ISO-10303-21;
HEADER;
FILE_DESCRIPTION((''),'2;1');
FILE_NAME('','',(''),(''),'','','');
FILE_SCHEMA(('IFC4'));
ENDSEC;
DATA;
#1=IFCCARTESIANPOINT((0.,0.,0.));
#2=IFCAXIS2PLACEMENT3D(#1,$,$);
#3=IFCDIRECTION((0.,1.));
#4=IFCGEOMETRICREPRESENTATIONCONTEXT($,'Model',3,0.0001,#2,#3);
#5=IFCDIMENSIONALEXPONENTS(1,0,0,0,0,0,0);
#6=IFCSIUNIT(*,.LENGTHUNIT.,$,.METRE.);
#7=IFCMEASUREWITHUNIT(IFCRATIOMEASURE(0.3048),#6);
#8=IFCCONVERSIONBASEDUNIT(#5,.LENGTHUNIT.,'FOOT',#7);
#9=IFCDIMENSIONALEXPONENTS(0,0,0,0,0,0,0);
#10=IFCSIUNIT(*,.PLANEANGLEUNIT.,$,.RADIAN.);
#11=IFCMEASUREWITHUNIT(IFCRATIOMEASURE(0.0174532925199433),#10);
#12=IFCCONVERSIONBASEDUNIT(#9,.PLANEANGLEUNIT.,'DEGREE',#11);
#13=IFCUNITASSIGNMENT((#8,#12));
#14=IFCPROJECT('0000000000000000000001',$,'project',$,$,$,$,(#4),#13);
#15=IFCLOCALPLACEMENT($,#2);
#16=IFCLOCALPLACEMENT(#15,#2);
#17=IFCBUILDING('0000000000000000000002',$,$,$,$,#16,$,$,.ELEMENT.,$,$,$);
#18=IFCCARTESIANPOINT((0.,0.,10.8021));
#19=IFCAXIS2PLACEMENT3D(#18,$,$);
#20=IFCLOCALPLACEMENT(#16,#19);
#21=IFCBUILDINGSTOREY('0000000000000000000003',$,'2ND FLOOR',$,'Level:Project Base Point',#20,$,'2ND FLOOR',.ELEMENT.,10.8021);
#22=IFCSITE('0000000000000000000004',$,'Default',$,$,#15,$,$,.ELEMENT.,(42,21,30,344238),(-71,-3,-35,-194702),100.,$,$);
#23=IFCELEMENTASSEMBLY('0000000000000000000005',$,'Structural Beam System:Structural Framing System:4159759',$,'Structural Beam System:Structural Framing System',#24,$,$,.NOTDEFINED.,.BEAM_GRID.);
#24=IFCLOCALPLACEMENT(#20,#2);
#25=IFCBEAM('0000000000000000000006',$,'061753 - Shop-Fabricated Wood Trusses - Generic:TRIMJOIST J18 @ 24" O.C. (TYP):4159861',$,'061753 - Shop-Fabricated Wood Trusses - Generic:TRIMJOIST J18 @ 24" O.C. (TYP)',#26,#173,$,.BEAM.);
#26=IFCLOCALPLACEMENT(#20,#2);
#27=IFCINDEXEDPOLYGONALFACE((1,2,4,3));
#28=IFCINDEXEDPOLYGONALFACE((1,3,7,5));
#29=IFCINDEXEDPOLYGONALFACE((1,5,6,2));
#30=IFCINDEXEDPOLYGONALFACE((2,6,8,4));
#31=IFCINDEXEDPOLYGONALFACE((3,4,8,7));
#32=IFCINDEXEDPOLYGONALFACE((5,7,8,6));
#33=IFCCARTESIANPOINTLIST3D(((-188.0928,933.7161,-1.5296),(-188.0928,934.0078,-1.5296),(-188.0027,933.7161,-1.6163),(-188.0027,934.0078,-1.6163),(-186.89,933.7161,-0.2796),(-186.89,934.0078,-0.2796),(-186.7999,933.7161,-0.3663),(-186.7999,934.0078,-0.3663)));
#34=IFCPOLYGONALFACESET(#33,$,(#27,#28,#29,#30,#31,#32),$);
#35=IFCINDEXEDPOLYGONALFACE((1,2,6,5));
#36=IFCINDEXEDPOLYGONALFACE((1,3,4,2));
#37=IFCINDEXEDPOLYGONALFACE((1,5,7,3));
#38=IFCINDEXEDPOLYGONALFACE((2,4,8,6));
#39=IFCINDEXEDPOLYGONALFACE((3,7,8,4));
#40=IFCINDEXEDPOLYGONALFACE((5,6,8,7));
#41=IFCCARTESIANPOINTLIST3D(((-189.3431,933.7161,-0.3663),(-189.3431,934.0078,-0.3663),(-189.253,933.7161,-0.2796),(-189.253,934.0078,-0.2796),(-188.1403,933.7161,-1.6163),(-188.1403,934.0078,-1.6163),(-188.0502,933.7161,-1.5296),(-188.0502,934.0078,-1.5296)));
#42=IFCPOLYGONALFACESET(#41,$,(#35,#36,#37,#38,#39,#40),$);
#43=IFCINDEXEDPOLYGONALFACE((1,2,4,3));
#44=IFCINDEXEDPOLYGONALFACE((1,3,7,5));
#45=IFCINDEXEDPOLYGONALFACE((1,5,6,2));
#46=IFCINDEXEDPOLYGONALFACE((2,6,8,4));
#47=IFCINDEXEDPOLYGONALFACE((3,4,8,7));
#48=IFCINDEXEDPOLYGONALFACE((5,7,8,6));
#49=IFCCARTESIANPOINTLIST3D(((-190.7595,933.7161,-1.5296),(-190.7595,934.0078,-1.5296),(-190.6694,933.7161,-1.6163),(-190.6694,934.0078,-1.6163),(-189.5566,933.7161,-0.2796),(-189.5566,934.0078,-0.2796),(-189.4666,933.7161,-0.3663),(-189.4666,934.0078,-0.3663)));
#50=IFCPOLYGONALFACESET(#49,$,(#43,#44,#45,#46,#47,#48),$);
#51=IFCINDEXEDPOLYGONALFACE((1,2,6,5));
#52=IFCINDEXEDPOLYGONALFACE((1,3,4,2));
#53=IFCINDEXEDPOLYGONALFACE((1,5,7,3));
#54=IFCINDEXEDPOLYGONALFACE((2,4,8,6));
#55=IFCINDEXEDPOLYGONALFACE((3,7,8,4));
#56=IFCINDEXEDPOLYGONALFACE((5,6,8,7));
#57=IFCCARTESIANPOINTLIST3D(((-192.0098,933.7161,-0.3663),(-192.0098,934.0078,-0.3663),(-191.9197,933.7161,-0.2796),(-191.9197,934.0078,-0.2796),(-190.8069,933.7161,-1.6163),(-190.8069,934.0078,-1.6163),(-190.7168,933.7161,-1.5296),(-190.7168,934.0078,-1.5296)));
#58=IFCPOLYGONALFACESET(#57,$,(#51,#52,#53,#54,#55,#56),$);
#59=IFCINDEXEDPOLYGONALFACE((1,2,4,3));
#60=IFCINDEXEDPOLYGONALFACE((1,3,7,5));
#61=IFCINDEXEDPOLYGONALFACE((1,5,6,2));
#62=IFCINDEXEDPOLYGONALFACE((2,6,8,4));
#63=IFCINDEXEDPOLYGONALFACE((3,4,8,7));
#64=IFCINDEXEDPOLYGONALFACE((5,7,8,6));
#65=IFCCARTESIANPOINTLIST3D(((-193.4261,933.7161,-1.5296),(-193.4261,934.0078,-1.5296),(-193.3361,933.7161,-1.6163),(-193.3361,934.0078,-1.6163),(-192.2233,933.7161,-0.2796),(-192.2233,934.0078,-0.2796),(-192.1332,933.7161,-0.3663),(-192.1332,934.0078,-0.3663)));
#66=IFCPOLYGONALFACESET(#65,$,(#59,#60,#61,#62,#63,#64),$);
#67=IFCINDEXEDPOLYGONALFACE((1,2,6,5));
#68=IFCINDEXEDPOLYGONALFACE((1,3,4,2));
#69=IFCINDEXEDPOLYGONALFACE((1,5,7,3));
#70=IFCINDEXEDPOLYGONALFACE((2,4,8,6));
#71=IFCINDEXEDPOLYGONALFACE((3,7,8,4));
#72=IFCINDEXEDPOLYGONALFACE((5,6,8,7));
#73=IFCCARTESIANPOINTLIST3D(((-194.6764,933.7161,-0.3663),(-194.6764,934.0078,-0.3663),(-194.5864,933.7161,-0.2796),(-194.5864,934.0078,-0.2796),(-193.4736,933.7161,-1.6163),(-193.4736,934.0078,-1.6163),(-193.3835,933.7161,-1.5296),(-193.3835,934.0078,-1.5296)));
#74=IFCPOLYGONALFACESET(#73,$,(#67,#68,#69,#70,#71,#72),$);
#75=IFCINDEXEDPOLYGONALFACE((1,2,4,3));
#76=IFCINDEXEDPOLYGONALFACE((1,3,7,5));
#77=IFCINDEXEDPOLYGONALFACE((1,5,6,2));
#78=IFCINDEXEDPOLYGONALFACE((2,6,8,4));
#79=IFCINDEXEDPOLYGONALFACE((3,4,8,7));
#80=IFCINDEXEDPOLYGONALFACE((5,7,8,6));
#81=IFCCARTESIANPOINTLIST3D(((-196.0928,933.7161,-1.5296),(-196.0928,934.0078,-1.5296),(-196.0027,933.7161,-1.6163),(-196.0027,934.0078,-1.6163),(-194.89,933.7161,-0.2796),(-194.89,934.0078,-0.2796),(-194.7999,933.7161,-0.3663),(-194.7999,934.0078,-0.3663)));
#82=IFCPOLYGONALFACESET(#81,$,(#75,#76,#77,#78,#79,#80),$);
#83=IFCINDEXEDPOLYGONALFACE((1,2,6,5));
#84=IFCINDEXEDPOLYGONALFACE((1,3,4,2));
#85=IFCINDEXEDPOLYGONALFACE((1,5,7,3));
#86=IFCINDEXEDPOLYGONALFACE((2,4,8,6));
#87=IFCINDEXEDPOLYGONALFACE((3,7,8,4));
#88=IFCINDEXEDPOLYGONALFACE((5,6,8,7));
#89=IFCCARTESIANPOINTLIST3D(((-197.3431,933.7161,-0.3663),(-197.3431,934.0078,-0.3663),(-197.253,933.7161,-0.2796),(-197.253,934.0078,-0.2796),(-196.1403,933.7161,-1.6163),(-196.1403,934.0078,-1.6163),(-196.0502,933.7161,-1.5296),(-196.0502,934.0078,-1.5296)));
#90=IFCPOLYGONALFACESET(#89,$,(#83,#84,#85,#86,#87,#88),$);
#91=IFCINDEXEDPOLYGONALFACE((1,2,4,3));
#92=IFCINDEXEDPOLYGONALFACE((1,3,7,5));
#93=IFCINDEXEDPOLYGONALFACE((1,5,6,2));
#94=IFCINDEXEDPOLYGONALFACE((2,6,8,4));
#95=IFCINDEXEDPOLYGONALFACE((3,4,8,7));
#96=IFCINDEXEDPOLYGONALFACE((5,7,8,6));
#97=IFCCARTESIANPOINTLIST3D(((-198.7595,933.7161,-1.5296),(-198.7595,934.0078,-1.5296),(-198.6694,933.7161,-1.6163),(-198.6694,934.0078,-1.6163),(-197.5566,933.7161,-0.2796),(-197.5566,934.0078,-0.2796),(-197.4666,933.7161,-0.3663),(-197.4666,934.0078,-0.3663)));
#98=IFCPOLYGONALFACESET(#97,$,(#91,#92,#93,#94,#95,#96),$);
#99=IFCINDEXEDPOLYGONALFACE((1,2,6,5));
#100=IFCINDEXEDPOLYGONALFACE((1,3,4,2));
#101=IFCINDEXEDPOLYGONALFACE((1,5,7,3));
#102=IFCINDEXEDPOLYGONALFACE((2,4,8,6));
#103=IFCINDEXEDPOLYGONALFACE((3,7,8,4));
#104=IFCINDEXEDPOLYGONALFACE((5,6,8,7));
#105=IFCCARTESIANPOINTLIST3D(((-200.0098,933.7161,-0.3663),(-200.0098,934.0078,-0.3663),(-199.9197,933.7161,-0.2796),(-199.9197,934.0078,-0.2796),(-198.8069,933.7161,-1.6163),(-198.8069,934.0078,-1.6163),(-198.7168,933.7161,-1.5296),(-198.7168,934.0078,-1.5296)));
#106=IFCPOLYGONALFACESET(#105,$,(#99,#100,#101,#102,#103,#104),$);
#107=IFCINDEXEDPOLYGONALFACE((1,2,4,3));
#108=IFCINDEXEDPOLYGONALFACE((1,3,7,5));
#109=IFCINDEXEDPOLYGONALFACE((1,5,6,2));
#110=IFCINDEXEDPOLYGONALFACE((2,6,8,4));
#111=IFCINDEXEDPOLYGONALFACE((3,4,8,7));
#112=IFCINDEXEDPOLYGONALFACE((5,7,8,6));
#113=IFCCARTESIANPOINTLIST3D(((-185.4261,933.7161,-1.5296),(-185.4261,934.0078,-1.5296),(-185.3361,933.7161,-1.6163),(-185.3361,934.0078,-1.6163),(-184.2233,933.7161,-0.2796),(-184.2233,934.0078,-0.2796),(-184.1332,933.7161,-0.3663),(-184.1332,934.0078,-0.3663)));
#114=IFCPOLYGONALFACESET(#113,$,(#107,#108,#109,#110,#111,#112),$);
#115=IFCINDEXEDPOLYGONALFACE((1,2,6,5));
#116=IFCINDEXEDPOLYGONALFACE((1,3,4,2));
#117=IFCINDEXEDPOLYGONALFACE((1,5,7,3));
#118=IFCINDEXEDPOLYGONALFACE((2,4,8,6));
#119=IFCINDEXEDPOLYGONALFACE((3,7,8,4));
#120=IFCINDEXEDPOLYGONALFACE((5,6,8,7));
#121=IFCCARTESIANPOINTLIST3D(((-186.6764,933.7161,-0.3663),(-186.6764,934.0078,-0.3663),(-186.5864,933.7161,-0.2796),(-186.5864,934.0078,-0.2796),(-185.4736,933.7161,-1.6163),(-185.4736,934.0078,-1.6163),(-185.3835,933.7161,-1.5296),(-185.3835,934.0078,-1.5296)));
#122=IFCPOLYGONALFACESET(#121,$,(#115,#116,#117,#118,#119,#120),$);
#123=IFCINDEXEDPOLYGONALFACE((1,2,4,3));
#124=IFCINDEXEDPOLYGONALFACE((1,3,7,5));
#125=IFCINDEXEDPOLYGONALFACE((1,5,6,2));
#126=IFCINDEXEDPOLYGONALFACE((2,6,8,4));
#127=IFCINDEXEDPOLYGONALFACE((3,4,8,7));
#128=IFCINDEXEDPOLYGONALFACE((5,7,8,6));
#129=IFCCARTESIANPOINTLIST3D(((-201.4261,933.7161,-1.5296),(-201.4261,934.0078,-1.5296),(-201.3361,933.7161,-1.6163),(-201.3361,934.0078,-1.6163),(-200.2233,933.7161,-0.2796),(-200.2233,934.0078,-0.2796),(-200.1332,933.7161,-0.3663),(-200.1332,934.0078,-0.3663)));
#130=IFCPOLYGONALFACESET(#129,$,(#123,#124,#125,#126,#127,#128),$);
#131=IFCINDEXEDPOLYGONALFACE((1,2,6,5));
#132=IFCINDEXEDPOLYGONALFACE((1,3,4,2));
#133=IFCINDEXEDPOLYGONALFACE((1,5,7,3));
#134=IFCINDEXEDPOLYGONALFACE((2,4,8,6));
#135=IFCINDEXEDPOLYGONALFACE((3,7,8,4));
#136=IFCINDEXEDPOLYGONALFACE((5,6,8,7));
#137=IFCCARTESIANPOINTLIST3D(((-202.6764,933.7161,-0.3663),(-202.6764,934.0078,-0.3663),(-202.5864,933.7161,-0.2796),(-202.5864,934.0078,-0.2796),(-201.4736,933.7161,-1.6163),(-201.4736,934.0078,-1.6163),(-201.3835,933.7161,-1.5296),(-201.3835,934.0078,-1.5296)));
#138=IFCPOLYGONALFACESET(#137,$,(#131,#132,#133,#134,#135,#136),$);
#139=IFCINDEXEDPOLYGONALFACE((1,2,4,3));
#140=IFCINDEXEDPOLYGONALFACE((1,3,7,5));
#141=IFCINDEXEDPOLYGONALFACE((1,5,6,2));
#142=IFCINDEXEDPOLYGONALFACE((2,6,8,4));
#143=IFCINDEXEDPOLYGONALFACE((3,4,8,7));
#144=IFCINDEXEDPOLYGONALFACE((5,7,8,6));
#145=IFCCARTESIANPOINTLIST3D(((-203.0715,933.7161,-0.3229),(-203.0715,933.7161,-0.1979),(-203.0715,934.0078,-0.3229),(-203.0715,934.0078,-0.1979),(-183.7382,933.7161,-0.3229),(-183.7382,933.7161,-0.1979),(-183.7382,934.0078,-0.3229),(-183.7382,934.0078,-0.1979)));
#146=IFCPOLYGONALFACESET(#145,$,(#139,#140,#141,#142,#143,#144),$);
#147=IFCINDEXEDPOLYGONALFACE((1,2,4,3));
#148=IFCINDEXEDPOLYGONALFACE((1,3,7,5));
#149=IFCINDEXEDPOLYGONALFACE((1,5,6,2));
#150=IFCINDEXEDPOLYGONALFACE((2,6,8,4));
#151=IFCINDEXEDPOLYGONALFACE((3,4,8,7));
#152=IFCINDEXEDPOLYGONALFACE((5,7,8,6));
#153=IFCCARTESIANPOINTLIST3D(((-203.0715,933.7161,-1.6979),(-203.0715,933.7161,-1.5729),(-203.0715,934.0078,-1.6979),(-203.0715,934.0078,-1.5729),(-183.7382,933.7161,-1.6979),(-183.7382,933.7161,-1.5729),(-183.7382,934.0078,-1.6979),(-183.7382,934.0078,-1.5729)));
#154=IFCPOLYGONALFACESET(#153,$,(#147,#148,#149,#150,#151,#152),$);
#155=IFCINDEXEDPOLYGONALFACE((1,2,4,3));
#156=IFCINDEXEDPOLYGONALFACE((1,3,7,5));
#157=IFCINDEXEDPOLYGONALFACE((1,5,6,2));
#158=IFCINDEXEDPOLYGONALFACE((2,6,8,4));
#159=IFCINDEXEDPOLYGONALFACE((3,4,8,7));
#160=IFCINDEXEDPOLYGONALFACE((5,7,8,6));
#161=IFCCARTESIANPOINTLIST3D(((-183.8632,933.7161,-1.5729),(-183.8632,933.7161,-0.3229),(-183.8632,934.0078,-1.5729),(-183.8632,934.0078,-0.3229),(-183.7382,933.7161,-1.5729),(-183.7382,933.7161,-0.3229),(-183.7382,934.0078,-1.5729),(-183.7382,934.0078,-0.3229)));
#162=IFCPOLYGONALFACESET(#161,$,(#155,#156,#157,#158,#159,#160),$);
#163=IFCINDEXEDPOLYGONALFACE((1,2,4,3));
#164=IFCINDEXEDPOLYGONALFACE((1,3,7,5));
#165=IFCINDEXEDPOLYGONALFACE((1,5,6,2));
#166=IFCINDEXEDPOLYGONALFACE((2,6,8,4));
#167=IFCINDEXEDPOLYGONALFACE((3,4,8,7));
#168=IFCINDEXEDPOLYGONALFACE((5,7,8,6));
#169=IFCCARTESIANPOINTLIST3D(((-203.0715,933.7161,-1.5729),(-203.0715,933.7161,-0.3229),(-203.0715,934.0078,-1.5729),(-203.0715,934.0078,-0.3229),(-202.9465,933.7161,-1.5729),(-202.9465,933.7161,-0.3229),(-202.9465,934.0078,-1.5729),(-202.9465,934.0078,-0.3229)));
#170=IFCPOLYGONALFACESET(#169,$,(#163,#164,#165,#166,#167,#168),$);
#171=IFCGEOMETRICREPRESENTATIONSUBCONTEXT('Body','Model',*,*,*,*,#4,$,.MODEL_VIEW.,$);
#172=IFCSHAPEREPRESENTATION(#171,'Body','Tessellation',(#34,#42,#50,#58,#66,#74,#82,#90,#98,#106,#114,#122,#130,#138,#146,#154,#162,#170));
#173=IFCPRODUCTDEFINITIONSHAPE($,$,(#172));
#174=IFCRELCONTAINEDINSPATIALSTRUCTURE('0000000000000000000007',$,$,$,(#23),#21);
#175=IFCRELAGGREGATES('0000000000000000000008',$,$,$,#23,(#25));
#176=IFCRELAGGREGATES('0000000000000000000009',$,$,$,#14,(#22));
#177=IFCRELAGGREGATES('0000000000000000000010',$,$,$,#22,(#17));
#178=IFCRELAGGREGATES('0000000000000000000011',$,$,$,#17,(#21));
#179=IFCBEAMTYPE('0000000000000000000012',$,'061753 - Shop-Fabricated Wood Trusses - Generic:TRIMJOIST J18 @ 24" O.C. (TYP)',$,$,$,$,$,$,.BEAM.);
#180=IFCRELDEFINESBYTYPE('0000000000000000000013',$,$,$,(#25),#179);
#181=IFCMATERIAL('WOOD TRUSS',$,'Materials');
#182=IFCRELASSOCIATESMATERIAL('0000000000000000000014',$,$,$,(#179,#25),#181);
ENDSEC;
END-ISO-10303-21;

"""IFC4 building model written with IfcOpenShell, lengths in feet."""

from ifc_helpers import new_model, entity, si_unit, converted_unit, direction, frame, frame_2d, origin, origin_2d_with_axis, place, context, subcontext, project, spatial, rectangle, extrude, source, transform, mapped, material, material_profile, profile_set, profile_usage, type_object, type_shapes, element, aggregate, save


model = new_model("IFC4")

# Units and contexts
model_context = context("Model", 3, precision=0.0001, world=origin(), true_north=direction((0.0, 1.0)))
body_context = subcontext(model_context, "Body", "Model", "MODEL_VIEW")
ifc_project = project(units=[converted_unit("LENGTHUNIT", "FOOT", entity("IfcRatioMeasure", 0.3048), si_unit("LENGTHUNIT", "METRE"), dimensions=[1, 0, 0, 0, 0, 0, 0]), converted_unit("PLANEANGLEUNIT", "DEGREE", entity("IfcRatioMeasure", 0.0174532925199433), si_unit("PLANEANGLEUNIT", "RADIAN"), dimensions=[0, 0, 0, 0, 0, 0, 0])], contexts=[model_context])

# Site, building, storey
site_placement = place(None, origin())
site = spatial("IfcSite", under=ifc_project, at=site_placement, Name="Default", CompositionType="ELEMENT", RefLatitude=(42, 21, 30, 344238), RefLongitude=(-71, -3, -35, -194702), RefElevation=100.0)
building_placement = place(site_placement, origin())
building = spatial("IfcBuilding", under=site, at=building_placement, CompositionType="ELEMENT")
storey_placement = place(building_placement, frame((0.0, 0.0, 10.8021)))
storey = spatial("IfcBuildingStorey", under=building, at=storey_placement, Name="2ND FLOOR", ObjectType="Level:Project Base Point", LongName="2ND FLOOR", CompositionType="ELEMENT", Elevation=10.8021)

# Element assembly, beam
ifc_material_1 = material(Name="WOOD TRUSS", Category="Materials")
ifc_material_profile_1 = material_profile(ifc_material_1, rectangle(XDim=1.7347, YDim=0.125, at=frame_2d((0.0, 0.0), x_axis=(1.0, 0.0))), Name="TRIMJOIST J18 @ 24\" O.C. (TYP)")
ifc_material_profile_2 = material_profile(ifc_material_1, rectangle(XDim=1.7347, YDim=0.125, at=frame_2d((0.0, 0.0), x_axis=(1.0, 0.0))), Name="TRIMJOIST J18 @ 24\" O.C. (TYP)")
ifc_material_profile_3 = material_profile(ifc_material_1, rectangle(XDim=1.7347, YDim=0.125, at=frame_2d((0.0, 0.0), x_axis=(1.0, 0.0))), Name="TRIMJOIST J18 @ 24\" O.C. (TYP)")
ifc_material_profile_4 = material_profile(ifc_material_1, rectangle(XDim=1.7347, YDim=0.125, at=frame_2d((0.0, 0.0), x_axis=(1.0, 0.0))), Name="TRIMJOIST J18 @ 24\" O.C. (TYP)")
ifc_material_profile_5 = material_profile(ifc_material_1, rectangle(XDim=1.7347, YDim=0.125, at=frame_2d((0.0, 0.0), x_axis=(1.0, 0.0))), Name="TRIMJOIST J18 @ 24\" O.C. (TYP)")
ifc_material_profile_6 = material_profile(ifc_material_1, rectangle(XDim=1.7347, YDim=0.125, at=frame_2d((0.0, 0.0), x_axis=(1.0, 0.0))), Name="TRIMJOIST J18 @ 24\" O.C. (TYP)")
ifc_material_profile_7 = material_profile(ifc_material_1, rectangle(XDim=1.7347, YDim=0.125, at=frame_2d((0.0, 0.0), x_axis=(1.0, 0.0))), Name="TRIMJOIST J18 @ 24\" O.C. (TYP)")
ifc_material_profile_8 = material_profile(ifc_material_1, rectangle(XDim=1.7347, YDim=0.125, at=frame_2d((0.0, 0.0), x_axis=(1.0, 0.0))), Name="TRIMJOIST J18 @ 24\" O.C. (TYP)")
ifc_material_profile_9 = material_profile(ifc_material_1, rectangle(XDim=1.7347, YDim=0.125, at=frame_2d((0.0, 0.0), x_axis=(1.0, 0.0))), Name="TRIMJOIST J18 @ 24\" O.C. (TYP)")
ifc_material_profile_10 = material_profile(ifc_material_1, rectangle(XDim=1.7347, YDim=0.125, at=origin_2d_with_axis()), Name="TRIMJOIST J18 @ 24\" O.C. (TYP)")
ifc_material_profile_11 = material_profile(ifc_material_1, rectangle(XDim=0.125, YDim=0.2917, at=origin_2d_with_axis()), Name="TRIMJOIST J18 @ 24\" O.C. (TYP)")
ifc_material_profile_12 = material_profile(ifc_material_1, rectangle(XDim=0.125, YDim=0.2917, at=origin_2d_with_axis()), Name="TRIMJOIST J18 @ 24\" O.C. (TYP)")
ifc_material_profile_13 = material_profile(ifc_material_1, rectangle(XDim=1.25, YDim=0.2917, at=origin_2d_with_axis()), Name="TRIMJOIST J18 @ 24\" O.C. (TYP)")
ifc_material_profile_14 = material_profile(ifc_material_1, rectangle(XDim=1.25, YDim=0.2917, at=origin_2d_with_axis()), Name="TRIMJOIST J18 @ 24\" O.C. (TYP)")
ifc_profile_set_1 = profile_set([ifc_material_profile_1, ifc_material_profile_2, ifc_material_profile_3, ifc_material_profile_4, ifc_material_profile_5, ifc_material_profile_6, ifc_material_profile_7, ifc_material_profile_8, ifc_material_profile_9, ifc_material_profile_10, ifc_material_profile_11, ifc_material_profile_12, ifc_material_profile_13, ifc_material_profile_14], Name="TRIMJOIST J18 @ 24\" O.C. (TYP)")
beam_type_1 = type_object("IfcBeamType", Name="061753 - Shop-Fabricated Wood Trusses - Generic:TRIMJOIST J18 @ 24\" O.C. (TYP)", PredefinedType="BEAM", material=ifc_profile_set_1)
shared_shape_1 = source(origin(), body_context, "Body", "SweptSolid", [
    extrude(rectangle(XDim=1.7347, YDim=0.125, at=frame_2d((0.0, 0.0), x_axis=(1.0, 0.0))), frame((5.9585, -0.1458, 0.0), z_axis=(0.0, 1.0, 0.0), x_axis=(0.693383, 0.0, 0.720569)), (0.0, 0.0, 1.0), 0.2917),
    extrude(rectangle(XDim=1.7347, YDim=0.125, at=origin_2d_with_axis()), frame((4.7082, -0.1458, 0.0), z_axis=(0.0, 1.0, 0.0), x_axis=(0.693383, 0.0, -0.720569)), (0.0, 0.0, 1.0), 0.2917),
    extrude(rectangle(XDim=1.7347, YDim=0.125, at=frame_2d((0.0, 0.0), x_axis=(1.0, 0.0))), frame((3.2918, -0.1458, 0.0), z_axis=(0.0, 1.0, 0.0), x_axis=(0.693383, 0.0, 0.720569)), (0.0, 0.0, 1.0), 0.2917),
    extrude(rectangle(XDim=1.7347, YDim=0.125, at=frame_2d((0.0, 0.0), x_axis=(1.0, 0.0))), frame((2.0415, -0.1458, 0.0), z_axis=(0.0, 1.0, 0.0), x_axis=(0.693383, 0.0, -0.720569)), (0.0, 0.0, 1.0), 0.2917),
    extrude(rectangle(XDim=1.7347, YDim=0.125, at=frame_2d((0.0, 0.0), x_axis=(1.0, 0.0))), frame((0.6251, -0.1458, 0.0), z_axis=(0.0, 1.0, 0.0), x_axis=(0.693383, 0.0, 0.720569)), (0.0, 0.0, 1.0), 0.2917),
    extrude(rectangle(XDim=1.7347, YDim=0.125, at=frame_2d((0.0, 0.0), x_axis=(1.0, 0.0))), frame((-0.6251, -0.1458, 0.0), z_axis=(0.0, 1.0, 0.0), x_axis=(0.693383, 0.0, -0.720569)), (0.0, 0.0, 1.0), 0.2917),
    extrude(rectangle(XDim=1.7347, YDim=0.125, at=frame_2d((0.0, 0.0), x_axis=(1.0, 0.0))), frame((-2.0415, -0.1458, 0.0), z_axis=(0.0, 1.0, 0.0), x_axis=(0.693383, 0.0, 0.720569)), (0.0, 0.0, 1.0), 0.2917),
    extrude(rectangle(XDim=1.7347, YDim=0.125, at=origin_2d_with_axis()), frame((-3.2918, -0.1458, 0.0), z_axis=(0.0, 1.0, 0.0), x_axis=(0.693383, 0.0, -0.720569)), (0.0, 0.0, 1.0), 0.2917),
    extrude(rectangle(XDim=1.7347, YDim=0.125, at=frame_2d((0.0, 0.0), x_axis=(1.0, 0.0))), frame((-4.7082, -0.1458, 0.0), z_axis=(0.0, 1.0, 0.0), x_axis=(0.693383, 0.0, 0.720569)), (0.0, 0.0, 1.0), 0.2917),
    extrude(rectangle(XDim=1.7347, YDim=0.125, at=frame_2d((0.0, 0.0), x_axis=(1.0, 0.0))), frame((-5.9585, -0.1458, 0.0), z_axis=(0.0, 1.0, 0.0), x_axis=(0.693383, 0.0, -0.720569)), (0.0, 0.0, 1.0), 0.2917),
    extrude(rectangle(XDim=1.7347, YDim=0.125, at=frame_2d((0.0, 0.0), x_axis=(1.0, 0.0))), frame((8.6251, -0.1458, 0.0), z_axis=(0.0, 1.0, 0.0), x_axis=(0.693383, 0.0, 0.720569)), (0.0, 0.0, 1.0), 0.2917),
    extrude(rectangle(XDim=1.7347, YDim=0.125, at=origin_2d_with_axis()), frame((7.3749, -0.1458, 0.0), z_axis=(0.0, 1.0, 0.0), x_axis=(0.693383, 0.0, -0.720569)), (0.0, 0.0, 1.0), 0.2917),
    extrude(rectangle(XDim=1.7347, YDim=0.125, at=frame_2d((0.0, 0.0), x_axis=(1.0, 0.0))), frame((-7.3749, -0.1458, 0.0), z_axis=(0.0, 1.0, 0.0), x_axis=(0.693383, 0.0, 0.720569)), (0.0, 0.0, 1.0), 0.2917),
    extrude(rectangle(XDim=1.7347, YDim=0.125, at=origin_2d_with_axis()), frame((-8.6251, -0.1458, 0.0), z_axis=(0.0, 1.0, 0.0), x_axis=(0.693383, 0.0, -0.720569)), (0.0, 0.0, 1.0), 0.2917),
    extrude(rectangle(XDim=0.125, YDim=0.2917, at=origin_2d_with_axis()), frame((-9.6667, 0.0, 0.6875), z_axis=(1.0, 0.0, 0.0), x_axis=(0.0, 0.0, -1.0)), (0.0, 0.0, 1.0), 19.3333),
    extrude(rectangle(XDim=0.125, YDim=0.2917, at=origin_2d_with_axis()), frame((-9.6667, 0.0, -0.6875), z_axis=(1.0, 0.0, 0.0), x_axis=(0.0, 0.0, -1.0)), (0.0, 0.0, 1.0), 19.3333),
    extrude(rectangle(XDim=1.25, YDim=0.2917, at=origin_2d_with_axis()), frame((9.5417, 0.0, 0.0), z_axis=(1.0, 0.0, 0.0), x_axis=(0.0, 0.0, -1.0)), (0.0, 0.0, 1.0), 0.125),
    extrude(rectangle(XDim=1.25, YDim=0.2917, at=origin_2d_with_axis()), frame((-9.6667, 0.0, 0.0), z_axis=(1.0, 0.0, 0.0), x_axis=(0.0, 0.0, -1.0)), (0.0, 0.0, 1.0), 0.125),
])
type_shapes(beam_type_1, [shared_shape_1])
assembly_1_placement = place(storey_placement, origin())
assembly_1 = element("IfcElementAssembly", 1, at=assembly_1_placement, inside=storey, Name="Structural Beam System:Structural Framing System:4159759", ObjectType="Structural Beam System:Structural Framing System", AssemblyPlace="NOTDEFINED", PredefinedType="BEAM_GRID")
ifc_profile_usage_1 = profile_usage(ifc_profile_set_1, cardinal=8)
beam_1_placement = place(assembly_1_placement, frame((-193.4048, 933.8619, -0.9479)))
beam_1 = element("IfcBeam", 2, at=beam_1_placement, type_object=beam_type_1, material=ifc_profile_usage_1, Name="061753 - Shop-Fabricated Wood Trusses - Generic:TRIMJOIST J18 @ 24\" O.C. (TYP):4159861", ObjectType="061753 - Shop-Fabricated Wood Trusses - Generic:TRIMJOIST J18 @ 24\" O.C. (TYP)", PredefinedType="BEAM", context=body_context, shape_type="MappedRepresentation", body=[
    mapped(shared_shape_1, transform((0.0, 0.0, 0.0), scale=1.0)),
])
aggregate(assembly_1, [beam_1])

save(model, "model.ifc")
